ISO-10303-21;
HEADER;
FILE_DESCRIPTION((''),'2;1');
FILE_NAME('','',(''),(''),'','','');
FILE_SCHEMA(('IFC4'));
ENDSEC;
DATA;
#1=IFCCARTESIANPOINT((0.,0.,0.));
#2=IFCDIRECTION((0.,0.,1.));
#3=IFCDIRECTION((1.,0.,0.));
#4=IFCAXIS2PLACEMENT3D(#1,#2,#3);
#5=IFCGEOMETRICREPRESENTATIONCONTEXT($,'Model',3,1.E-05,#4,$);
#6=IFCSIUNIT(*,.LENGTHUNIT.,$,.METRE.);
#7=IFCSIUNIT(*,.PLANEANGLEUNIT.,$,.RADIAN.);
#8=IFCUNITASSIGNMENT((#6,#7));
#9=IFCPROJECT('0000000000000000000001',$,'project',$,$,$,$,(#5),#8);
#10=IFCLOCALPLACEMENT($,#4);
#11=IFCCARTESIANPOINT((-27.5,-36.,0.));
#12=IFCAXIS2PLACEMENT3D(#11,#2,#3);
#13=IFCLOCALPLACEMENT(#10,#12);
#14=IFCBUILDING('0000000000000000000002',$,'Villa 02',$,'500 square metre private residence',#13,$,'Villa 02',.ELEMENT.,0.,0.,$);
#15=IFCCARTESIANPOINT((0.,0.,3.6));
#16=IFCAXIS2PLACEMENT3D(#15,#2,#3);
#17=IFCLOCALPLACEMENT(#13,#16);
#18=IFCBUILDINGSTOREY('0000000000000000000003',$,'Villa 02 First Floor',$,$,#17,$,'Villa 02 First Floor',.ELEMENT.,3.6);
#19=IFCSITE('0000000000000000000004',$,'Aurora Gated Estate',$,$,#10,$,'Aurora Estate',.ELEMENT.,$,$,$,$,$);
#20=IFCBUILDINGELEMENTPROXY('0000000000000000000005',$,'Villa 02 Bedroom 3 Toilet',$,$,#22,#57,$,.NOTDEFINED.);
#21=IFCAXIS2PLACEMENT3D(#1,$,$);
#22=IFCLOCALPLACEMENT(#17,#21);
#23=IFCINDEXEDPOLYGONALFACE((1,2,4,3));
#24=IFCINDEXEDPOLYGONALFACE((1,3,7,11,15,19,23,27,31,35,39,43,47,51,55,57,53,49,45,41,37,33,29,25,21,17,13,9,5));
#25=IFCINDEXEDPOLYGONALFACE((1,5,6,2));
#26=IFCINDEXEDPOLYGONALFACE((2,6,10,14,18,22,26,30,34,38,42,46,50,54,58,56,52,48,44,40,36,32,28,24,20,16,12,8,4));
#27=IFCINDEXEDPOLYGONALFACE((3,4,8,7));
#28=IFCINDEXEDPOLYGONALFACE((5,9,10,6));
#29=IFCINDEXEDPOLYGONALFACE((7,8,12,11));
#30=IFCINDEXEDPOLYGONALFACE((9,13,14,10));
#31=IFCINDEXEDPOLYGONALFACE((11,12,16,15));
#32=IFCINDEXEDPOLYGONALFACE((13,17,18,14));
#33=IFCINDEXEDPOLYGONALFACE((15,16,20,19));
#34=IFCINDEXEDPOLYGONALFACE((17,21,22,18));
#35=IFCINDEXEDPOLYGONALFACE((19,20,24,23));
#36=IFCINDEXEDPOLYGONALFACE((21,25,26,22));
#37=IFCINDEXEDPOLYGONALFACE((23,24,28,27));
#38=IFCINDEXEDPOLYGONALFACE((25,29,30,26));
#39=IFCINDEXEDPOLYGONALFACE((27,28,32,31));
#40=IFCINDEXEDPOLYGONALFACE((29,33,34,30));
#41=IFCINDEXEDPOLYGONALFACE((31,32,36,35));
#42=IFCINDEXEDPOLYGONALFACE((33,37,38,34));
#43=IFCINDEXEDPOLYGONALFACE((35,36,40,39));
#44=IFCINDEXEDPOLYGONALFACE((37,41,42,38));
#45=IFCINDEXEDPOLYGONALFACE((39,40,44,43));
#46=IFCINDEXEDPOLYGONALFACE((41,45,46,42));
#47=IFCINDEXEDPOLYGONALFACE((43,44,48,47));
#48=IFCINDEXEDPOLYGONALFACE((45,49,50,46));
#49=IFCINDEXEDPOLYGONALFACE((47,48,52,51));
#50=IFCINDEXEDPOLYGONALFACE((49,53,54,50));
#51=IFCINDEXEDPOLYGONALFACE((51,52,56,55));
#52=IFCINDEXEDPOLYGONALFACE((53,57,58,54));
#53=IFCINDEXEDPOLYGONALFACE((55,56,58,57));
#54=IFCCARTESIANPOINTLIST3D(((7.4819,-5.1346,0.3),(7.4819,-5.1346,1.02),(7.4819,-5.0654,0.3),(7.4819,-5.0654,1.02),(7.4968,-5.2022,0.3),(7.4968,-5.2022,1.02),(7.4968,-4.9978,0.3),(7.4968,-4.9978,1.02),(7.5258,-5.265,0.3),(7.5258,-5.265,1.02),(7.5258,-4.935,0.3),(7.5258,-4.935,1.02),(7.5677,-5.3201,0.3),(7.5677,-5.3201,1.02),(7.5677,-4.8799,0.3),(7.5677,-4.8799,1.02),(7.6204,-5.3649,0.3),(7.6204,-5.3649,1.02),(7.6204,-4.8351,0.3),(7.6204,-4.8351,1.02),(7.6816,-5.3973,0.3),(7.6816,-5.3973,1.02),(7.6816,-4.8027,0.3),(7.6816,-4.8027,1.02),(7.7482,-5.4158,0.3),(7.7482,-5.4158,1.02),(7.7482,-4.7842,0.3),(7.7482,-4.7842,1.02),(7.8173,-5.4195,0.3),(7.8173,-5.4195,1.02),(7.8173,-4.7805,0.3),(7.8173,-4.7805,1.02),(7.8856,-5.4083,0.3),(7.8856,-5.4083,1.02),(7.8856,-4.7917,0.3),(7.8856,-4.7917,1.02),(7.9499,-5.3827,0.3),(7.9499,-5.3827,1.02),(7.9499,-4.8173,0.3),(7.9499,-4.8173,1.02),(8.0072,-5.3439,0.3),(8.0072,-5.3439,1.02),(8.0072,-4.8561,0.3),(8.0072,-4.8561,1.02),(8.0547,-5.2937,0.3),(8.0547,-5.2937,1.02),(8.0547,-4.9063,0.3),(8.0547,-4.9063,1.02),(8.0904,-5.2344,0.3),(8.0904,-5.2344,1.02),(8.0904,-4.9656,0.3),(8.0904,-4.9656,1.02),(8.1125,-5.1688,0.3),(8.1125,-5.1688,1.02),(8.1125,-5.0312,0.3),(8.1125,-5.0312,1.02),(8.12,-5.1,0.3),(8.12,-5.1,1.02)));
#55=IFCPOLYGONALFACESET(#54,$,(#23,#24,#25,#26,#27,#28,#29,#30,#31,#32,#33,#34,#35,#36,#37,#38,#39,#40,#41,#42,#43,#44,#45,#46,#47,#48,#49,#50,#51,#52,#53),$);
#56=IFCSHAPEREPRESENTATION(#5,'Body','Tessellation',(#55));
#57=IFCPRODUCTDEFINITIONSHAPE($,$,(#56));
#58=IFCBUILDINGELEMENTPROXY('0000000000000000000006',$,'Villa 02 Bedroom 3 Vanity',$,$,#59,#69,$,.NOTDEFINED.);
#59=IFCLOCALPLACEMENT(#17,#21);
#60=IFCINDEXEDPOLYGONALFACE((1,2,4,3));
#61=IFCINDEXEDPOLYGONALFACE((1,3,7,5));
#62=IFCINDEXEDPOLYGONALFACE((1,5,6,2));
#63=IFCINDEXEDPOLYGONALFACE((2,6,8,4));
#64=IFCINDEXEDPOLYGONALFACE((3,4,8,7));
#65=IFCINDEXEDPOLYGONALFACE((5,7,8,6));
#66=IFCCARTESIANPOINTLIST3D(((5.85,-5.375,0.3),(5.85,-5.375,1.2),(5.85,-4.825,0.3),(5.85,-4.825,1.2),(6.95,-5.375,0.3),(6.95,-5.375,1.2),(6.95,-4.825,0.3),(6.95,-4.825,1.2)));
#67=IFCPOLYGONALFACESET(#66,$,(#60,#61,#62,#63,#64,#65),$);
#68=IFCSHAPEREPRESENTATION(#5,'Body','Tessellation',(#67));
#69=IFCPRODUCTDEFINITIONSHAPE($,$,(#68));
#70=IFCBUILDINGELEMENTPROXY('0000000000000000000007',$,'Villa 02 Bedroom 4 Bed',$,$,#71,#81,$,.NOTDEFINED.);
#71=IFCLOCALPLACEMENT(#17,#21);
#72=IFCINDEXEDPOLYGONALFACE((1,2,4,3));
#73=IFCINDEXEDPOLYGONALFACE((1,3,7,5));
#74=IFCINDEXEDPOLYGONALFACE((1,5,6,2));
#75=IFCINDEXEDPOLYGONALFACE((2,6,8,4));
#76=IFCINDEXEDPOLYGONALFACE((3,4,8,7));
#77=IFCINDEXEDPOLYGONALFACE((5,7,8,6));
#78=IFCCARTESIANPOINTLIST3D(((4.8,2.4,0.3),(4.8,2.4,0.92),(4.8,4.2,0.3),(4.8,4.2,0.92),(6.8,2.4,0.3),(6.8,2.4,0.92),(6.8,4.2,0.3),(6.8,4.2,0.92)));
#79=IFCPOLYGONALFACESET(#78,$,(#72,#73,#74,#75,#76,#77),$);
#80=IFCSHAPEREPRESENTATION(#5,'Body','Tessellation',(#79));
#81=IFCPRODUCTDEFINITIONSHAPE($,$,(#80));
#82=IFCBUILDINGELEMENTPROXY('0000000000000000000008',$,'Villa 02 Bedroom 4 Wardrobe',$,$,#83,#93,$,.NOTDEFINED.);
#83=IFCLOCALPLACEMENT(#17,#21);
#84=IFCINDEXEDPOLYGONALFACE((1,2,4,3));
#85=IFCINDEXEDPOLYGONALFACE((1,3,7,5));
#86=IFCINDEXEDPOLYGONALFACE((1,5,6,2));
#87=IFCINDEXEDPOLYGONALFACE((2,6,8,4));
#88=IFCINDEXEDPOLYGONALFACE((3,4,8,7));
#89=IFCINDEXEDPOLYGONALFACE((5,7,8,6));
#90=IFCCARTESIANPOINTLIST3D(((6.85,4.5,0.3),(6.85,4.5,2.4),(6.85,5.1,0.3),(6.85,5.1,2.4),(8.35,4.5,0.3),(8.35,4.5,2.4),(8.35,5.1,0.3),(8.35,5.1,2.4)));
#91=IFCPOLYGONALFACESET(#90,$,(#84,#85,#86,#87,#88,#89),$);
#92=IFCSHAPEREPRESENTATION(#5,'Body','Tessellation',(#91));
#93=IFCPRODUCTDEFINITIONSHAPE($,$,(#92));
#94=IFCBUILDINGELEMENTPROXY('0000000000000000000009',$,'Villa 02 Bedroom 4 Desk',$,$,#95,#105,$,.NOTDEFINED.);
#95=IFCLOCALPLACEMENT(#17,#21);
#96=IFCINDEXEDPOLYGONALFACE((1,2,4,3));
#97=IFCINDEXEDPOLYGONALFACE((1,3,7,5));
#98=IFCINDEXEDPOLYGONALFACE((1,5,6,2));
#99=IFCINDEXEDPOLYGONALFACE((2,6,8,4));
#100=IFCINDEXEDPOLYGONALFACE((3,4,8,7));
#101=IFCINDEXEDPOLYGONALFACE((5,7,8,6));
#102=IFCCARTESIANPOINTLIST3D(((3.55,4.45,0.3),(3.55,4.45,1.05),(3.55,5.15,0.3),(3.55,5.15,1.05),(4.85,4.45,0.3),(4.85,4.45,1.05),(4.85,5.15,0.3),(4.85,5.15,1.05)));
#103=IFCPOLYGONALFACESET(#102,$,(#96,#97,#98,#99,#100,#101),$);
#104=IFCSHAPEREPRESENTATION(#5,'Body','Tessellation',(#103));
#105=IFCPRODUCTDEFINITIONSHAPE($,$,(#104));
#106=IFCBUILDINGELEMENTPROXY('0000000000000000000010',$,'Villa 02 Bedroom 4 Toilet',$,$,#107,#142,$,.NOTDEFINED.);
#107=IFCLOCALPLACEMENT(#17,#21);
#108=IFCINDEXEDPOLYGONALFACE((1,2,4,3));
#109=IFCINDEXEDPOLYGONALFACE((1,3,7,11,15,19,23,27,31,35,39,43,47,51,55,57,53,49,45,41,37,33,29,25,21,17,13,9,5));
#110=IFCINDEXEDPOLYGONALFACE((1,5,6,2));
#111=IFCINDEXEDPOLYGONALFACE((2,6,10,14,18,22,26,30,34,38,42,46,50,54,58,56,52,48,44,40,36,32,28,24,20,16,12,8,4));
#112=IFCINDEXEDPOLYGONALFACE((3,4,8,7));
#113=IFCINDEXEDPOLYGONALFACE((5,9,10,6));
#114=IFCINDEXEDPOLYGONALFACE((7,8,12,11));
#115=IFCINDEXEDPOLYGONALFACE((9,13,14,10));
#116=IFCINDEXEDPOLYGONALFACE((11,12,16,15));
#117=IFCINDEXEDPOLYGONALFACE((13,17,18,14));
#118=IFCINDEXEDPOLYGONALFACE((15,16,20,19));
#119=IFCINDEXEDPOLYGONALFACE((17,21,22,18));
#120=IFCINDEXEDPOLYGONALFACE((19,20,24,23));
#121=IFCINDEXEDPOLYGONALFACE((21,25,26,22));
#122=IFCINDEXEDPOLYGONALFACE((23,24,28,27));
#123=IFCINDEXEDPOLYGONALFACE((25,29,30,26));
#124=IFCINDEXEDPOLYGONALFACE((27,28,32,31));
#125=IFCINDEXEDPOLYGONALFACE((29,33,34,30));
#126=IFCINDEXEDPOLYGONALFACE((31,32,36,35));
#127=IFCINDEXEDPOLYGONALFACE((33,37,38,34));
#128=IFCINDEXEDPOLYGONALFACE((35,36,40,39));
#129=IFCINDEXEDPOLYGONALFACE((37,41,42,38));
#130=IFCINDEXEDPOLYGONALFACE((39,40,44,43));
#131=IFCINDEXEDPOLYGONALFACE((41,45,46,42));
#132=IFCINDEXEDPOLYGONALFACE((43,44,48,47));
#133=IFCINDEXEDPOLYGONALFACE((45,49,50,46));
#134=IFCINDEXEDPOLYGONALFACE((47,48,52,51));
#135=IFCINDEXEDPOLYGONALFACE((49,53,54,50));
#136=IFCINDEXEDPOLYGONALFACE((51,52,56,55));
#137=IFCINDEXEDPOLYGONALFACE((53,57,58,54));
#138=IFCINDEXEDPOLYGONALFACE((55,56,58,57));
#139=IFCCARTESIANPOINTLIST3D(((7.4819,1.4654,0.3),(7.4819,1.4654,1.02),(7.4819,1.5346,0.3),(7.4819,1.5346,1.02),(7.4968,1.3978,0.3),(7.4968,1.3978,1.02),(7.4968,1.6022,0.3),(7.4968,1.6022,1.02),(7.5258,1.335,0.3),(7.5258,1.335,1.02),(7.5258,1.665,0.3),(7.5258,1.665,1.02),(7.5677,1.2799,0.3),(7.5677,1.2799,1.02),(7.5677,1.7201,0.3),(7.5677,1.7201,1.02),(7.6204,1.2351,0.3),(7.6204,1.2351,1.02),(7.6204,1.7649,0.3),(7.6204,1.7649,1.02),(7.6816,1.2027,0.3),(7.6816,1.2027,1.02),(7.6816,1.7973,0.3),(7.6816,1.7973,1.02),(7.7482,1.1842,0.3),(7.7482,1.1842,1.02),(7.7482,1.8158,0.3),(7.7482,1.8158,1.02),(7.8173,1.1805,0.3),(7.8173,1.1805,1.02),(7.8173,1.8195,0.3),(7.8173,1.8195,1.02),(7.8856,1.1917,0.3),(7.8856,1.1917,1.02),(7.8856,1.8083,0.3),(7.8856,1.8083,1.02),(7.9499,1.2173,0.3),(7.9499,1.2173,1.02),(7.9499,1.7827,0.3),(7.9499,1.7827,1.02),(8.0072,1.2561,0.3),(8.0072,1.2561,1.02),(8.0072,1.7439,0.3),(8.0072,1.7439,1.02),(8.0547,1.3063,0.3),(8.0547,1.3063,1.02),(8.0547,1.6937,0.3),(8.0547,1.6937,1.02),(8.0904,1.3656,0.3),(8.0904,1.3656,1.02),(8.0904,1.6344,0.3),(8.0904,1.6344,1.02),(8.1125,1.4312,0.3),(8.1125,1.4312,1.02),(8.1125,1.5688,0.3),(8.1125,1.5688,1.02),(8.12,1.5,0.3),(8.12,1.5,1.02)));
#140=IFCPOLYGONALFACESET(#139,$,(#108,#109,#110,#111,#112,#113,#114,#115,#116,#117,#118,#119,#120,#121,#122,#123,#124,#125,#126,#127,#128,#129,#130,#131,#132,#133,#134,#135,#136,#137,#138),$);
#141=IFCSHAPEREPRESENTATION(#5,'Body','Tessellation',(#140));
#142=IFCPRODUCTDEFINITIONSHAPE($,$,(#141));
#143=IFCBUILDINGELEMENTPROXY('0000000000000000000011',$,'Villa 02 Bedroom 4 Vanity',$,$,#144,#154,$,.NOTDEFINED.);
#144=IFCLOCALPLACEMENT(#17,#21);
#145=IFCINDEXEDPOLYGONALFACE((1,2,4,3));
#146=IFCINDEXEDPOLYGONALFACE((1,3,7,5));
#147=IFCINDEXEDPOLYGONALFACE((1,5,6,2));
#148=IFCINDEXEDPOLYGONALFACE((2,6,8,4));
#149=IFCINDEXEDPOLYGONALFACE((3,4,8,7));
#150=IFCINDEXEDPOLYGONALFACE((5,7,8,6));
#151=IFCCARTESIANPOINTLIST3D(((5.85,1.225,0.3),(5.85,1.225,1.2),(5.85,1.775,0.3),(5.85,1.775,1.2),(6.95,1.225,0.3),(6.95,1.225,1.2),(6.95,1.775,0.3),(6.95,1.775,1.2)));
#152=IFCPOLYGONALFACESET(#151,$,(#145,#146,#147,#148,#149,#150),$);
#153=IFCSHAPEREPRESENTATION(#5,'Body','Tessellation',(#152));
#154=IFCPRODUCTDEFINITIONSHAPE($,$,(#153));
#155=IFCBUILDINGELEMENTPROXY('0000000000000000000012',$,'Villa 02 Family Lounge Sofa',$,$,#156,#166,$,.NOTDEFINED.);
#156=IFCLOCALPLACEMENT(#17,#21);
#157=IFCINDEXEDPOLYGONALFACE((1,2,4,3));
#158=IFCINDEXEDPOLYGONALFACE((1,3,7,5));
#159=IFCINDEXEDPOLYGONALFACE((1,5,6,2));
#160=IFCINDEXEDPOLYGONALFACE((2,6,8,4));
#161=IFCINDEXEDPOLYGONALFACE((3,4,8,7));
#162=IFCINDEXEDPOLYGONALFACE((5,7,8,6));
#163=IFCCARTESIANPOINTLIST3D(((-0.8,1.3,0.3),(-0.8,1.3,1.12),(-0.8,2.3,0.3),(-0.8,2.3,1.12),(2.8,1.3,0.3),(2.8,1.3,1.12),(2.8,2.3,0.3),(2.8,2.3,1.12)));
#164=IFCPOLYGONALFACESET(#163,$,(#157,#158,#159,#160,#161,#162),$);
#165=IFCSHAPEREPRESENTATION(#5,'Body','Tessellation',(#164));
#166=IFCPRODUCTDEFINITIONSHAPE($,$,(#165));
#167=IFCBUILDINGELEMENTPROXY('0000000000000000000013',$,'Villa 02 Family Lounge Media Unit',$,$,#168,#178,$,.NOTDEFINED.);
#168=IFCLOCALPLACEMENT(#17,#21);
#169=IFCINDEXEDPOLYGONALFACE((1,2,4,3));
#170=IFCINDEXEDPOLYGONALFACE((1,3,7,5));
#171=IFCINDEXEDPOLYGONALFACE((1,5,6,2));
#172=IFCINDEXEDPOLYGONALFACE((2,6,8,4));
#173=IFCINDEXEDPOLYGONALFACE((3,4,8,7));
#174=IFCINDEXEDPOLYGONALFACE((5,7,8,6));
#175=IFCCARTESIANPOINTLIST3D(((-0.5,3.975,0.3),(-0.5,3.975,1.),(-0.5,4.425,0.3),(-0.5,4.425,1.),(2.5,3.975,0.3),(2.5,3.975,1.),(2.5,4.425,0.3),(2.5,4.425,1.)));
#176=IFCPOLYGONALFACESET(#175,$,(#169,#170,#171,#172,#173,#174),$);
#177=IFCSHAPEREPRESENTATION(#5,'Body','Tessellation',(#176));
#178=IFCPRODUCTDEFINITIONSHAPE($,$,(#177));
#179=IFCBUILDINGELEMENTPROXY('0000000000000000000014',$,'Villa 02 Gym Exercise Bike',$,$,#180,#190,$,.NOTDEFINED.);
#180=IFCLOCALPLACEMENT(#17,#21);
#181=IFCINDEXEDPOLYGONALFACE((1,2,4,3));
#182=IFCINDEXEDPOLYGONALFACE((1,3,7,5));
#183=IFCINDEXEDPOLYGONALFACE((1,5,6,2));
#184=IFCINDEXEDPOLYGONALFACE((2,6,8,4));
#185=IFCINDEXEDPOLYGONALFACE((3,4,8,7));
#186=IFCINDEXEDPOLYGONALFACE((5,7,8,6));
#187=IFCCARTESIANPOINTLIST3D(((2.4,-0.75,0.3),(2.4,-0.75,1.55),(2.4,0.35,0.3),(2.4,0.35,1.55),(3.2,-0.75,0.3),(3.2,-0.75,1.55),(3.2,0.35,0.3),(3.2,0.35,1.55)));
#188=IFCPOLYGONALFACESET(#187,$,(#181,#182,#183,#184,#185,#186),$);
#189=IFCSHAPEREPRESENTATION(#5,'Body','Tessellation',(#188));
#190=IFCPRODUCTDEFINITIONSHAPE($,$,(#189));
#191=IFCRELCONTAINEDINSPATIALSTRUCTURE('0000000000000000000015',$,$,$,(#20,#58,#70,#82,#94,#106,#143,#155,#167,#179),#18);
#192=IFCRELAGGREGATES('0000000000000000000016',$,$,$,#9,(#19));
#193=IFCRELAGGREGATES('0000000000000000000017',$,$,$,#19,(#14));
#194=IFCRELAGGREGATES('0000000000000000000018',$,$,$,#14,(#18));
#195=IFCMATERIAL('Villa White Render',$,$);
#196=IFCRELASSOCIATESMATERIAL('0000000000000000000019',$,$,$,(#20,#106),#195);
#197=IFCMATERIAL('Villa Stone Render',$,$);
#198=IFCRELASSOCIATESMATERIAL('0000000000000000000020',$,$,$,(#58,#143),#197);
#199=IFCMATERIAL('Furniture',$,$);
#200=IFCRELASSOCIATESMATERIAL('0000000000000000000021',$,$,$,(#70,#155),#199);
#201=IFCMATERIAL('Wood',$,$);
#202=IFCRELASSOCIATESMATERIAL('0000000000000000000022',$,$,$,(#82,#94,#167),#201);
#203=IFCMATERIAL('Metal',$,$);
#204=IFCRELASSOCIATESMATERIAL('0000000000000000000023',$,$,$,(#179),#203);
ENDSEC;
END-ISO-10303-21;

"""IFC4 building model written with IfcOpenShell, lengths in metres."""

from ifc_helpers import new_model, si_unit, frame, origin_with_axes, origin_2d_with_axis, place, context, project, spatial, rectangle, circle, extrude, material, element, save


model = new_model("IFC4")

# Units and contexts
model_context = context("Model", 3, precision=1e-05, world=origin_with_axes())
ifc_project = project(units=[si_unit("LENGTHUNIT", "METRE"), si_unit("PLANEANGLEUNIT", "RADIAN")], contexts=[model_context])

# Site, building, storey
site_placement = place(None, origin_with_axes())
site = spatial("IfcSite", under=ifc_project, at=site_placement, Name="Aurora Gated Estate", LongName="Aurora Estate", CompositionType="ELEMENT")
building_placement = place(site_placement, frame((-27.5, -36.0, 0.0), z_axis=(0.0, 0.0, 1.0), x_axis=(1.0, 0.0, 0.0)))
building = spatial("IfcBuilding", under=site, at=building_placement, Name="Villa 02", ObjectType="500 square metre private residence", LongName="Villa 02", CompositionType="ELEMENT", ElevationOfRefHeight=0.0, ElevationOfTerrain=0.0)
storey_placement = place(building_placement, frame((0.0, 0.0, 3.6), z_axis=(0.0, 0.0, 1.0), x_axis=(1.0, 0.0, 0.0)))
storey = spatial("IfcBuildingStorey", under=building, at=storey_placement, Name="Villa 02 First Floor", LongName="Villa 02 First Floor", CompositionType="ELEMENT", Elevation=3.6)

# Building element proxies
ifc_material_1 = material(Name="Wood")
ifc_material_2 = material(Name="Villa White Render")
ifc_material_3 = material(Name="Villa Stone Render")
ifc_material_4 = material(Name="Furniture")
proxy_1_placement = place(storey_placement, frame((7.8, -5.1, 0.3), z_axis=(0.0, 0.0, 1.0), x_axis=(1.0, 0.0, 0.0)))
element("IfcBuildingElementProxy", 1, at=proxy_1_placement, inside=storey, material=ifc_material_2, Name="Villa 02 Bedroom 3 Toilet", PredefinedType="NOTDEFINED", context=model_context, shape_type="SweptSolid", body=[
    extrude(circle(Radius=0.32, at=origin_2d_with_axis()), origin_with_axes(), (0.0, 0.0, 1.0), 0.72),
])
proxy_2_placement = place(storey_placement, frame((6.4, -5.1, 0.3), z_axis=(0.0, 0.0, 1.0), x_axis=(1.0, 0.0, 0.0)))
element("IfcBuildingElementProxy", 2, at=proxy_2_placement, inside=storey, material=ifc_material_3, Name="Villa 02 Bedroom 3 Vanity", PredefinedType="NOTDEFINED", context=model_context, shape_type="SweptSolid", body=[
    extrude(rectangle(XDim=1.1, YDim=0.55, at=origin_2d_with_axis()), origin_with_axes(), (0.0, 0.0, 1.0), 0.9),
])
proxy_3_placement = place(storey_placement, frame((5.8, 3.3, 0.3), z_axis=(0.0, 0.0, 1.0), x_axis=(1.0, 0.0, 0.0)))
element("IfcBuildingElementProxy", 3, at=proxy_3_placement, inside=storey, material=ifc_material_4, Name="Villa 02 Bedroom 4 Bed", PredefinedType="NOTDEFINED", context=model_context, shape_type="SweptSolid", body=[
    extrude(rectangle(XDim=2.0, YDim=1.8, at=origin_2d_with_axis()), origin_with_axes(), (0.0, 0.0, 1.0), 0.62),
])
proxy_4_placement = place(storey_placement, frame((7.6, 4.8, 0.3), z_axis=(0.0, 0.0, 1.0), x_axis=(1.0, 0.0, 0.0)))
element("IfcBuildingElementProxy", 4, at=proxy_4_placement, inside=storey, material=ifc_material_1, Name="Villa 02 Bedroom 4 Wardrobe", PredefinedType="NOTDEFINED", context=model_context, shape_type="SweptSolid", body=[
    extrude(rectangle(XDim=1.5, YDim=0.6, at=origin_2d_with_axis()), origin_with_axes(), (0.0, 0.0, 1.0), 2.1),
])
proxy_5_placement = place(storey_placement, frame((4.2, 4.8, 0.3), z_axis=(0.0, 0.0, 1.0), x_axis=(1.0, 0.0, 0.0)))
element("IfcBuildingElementProxy", 5, at=proxy_5_placement, inside=storey, material=ifc_material_1, Name="Villa 02 Bedroom 4 Desk", PredefinedType="NOTDEFINED", context=model_context, shape_type="SweptSolid", body=[
    extrude(rectangle(XDim=1.3, YDim=0.7, at=origin_2d_with_axis()), origin_with_axes(), (0.0, 0.0, 1.0), 0.75),
])
proxy_6_placement = place(storey_placement, frame((7.8, 1.5, 0.3), z_axis=(0.0, 0.0, 1.0), x_axis=(1.0, 0.0, 0.0)))
element("IfcBuildingElementProxy", 6, at=proxy_6_placement, inside=storey, material=ifc_material_2, Name="Villa 02 Bedroom 4 Toilet", PredefinedType="NOTDEFINED", context=model_context, shape_type="SweptSolid", body=[
    extrude(circle(Radius=0.32, at=origin_2d_with_axis()), origin_with_axes(), (0.0, 0.0, 1.0), 0.72),
])
proxy_7_placement = place(storey_placement, frame((6.4, 1.5, 0.3), z_axis=(0.0, 0.0, 1.0), x_axis=(1.0, 0.0, 0.0)))
element("IfcBuildingElementProxy", 7, at=proxy_7_placement, inside=storey, material=ifc_material_3, Name="Villa 02 Bedroom 4 Vanity", PredefinedType="NOTDEFINED", context=model_context, shape_type="SweptSolid", body=[
    extrude(rectangle(XDim=1.1, YDim=0.55, at=origin_2d_with_axis()), origin_with_axes(), (0.0, 0.0, 1.0), 0.9),
])
proxy_8_placement = place(storey_placement, frame((1.0, 1.8, 0.3), z_axis=(0.0, 0.0, 1.0), x_axis=(1.0, 0.0, 0.0)))
element("IfcBuildingElementProxy", 8, at=proxy_8_placement, inside=storey, material=ifc_material_4, Name="Villa 02 Family Lounge Sofa", PredefinedType="NOTDEFINED", context=model_context, shape_type="SweptSolid", body=[
    extrude(rectangle(XDim=3.6, YDim=1.0, at=origin_2d_with_axis()), origin_with_axes(), (0.0, 0.0, 1.0), 0.82),
])
proxy_9_placement = place(storey_placement, frame((1.0, 4.2, 0.3), z_axis=(0.0, 0.0, 1.0), x_axis=(1.0, 0.0, 0.0)))
element("IfcBuildingElementProxy", 9, at=proxy_9_placement, inside=storey, material=ifc_material_1, Name="Villa 02 Family Lounge Media Unit", PredefinedType="NOTDEFINED", context=model_context, shape_type="SweptSolid", body=[
    extrude(rectangle(XDim=3.0, YDim=0.45, at=origin_2d_with_axis()), origin_with_axes(), (0.0, 0.0, 1.0), 0.7),
])
ifc_material_5 = material(Name="Metal")
proxy_10_placement = place(storey_placement, frame((2.8, -0.2, 0.3), z_axis=(0.0, 0.0, 1.0), x_axis=(1.0, 0.0, 0.0)))
element("IfcBuildingElementProxy", 10, at=proxy_10_placement, inside=storey, material=ifc_material_5, Name="Villa 02 Gym Exercise Bike", PredefinedType="NOTDEFINED", context=model_context, shape_type="SweptSolid", body=[
    extrude(rectangle(XDim=0.8, YDim=1.1, at=origin_2d_with_axis()), origin_with_axes(), (0.0, 0.0, 1.0), 1.25),
])

save(model, "model.ifc")
